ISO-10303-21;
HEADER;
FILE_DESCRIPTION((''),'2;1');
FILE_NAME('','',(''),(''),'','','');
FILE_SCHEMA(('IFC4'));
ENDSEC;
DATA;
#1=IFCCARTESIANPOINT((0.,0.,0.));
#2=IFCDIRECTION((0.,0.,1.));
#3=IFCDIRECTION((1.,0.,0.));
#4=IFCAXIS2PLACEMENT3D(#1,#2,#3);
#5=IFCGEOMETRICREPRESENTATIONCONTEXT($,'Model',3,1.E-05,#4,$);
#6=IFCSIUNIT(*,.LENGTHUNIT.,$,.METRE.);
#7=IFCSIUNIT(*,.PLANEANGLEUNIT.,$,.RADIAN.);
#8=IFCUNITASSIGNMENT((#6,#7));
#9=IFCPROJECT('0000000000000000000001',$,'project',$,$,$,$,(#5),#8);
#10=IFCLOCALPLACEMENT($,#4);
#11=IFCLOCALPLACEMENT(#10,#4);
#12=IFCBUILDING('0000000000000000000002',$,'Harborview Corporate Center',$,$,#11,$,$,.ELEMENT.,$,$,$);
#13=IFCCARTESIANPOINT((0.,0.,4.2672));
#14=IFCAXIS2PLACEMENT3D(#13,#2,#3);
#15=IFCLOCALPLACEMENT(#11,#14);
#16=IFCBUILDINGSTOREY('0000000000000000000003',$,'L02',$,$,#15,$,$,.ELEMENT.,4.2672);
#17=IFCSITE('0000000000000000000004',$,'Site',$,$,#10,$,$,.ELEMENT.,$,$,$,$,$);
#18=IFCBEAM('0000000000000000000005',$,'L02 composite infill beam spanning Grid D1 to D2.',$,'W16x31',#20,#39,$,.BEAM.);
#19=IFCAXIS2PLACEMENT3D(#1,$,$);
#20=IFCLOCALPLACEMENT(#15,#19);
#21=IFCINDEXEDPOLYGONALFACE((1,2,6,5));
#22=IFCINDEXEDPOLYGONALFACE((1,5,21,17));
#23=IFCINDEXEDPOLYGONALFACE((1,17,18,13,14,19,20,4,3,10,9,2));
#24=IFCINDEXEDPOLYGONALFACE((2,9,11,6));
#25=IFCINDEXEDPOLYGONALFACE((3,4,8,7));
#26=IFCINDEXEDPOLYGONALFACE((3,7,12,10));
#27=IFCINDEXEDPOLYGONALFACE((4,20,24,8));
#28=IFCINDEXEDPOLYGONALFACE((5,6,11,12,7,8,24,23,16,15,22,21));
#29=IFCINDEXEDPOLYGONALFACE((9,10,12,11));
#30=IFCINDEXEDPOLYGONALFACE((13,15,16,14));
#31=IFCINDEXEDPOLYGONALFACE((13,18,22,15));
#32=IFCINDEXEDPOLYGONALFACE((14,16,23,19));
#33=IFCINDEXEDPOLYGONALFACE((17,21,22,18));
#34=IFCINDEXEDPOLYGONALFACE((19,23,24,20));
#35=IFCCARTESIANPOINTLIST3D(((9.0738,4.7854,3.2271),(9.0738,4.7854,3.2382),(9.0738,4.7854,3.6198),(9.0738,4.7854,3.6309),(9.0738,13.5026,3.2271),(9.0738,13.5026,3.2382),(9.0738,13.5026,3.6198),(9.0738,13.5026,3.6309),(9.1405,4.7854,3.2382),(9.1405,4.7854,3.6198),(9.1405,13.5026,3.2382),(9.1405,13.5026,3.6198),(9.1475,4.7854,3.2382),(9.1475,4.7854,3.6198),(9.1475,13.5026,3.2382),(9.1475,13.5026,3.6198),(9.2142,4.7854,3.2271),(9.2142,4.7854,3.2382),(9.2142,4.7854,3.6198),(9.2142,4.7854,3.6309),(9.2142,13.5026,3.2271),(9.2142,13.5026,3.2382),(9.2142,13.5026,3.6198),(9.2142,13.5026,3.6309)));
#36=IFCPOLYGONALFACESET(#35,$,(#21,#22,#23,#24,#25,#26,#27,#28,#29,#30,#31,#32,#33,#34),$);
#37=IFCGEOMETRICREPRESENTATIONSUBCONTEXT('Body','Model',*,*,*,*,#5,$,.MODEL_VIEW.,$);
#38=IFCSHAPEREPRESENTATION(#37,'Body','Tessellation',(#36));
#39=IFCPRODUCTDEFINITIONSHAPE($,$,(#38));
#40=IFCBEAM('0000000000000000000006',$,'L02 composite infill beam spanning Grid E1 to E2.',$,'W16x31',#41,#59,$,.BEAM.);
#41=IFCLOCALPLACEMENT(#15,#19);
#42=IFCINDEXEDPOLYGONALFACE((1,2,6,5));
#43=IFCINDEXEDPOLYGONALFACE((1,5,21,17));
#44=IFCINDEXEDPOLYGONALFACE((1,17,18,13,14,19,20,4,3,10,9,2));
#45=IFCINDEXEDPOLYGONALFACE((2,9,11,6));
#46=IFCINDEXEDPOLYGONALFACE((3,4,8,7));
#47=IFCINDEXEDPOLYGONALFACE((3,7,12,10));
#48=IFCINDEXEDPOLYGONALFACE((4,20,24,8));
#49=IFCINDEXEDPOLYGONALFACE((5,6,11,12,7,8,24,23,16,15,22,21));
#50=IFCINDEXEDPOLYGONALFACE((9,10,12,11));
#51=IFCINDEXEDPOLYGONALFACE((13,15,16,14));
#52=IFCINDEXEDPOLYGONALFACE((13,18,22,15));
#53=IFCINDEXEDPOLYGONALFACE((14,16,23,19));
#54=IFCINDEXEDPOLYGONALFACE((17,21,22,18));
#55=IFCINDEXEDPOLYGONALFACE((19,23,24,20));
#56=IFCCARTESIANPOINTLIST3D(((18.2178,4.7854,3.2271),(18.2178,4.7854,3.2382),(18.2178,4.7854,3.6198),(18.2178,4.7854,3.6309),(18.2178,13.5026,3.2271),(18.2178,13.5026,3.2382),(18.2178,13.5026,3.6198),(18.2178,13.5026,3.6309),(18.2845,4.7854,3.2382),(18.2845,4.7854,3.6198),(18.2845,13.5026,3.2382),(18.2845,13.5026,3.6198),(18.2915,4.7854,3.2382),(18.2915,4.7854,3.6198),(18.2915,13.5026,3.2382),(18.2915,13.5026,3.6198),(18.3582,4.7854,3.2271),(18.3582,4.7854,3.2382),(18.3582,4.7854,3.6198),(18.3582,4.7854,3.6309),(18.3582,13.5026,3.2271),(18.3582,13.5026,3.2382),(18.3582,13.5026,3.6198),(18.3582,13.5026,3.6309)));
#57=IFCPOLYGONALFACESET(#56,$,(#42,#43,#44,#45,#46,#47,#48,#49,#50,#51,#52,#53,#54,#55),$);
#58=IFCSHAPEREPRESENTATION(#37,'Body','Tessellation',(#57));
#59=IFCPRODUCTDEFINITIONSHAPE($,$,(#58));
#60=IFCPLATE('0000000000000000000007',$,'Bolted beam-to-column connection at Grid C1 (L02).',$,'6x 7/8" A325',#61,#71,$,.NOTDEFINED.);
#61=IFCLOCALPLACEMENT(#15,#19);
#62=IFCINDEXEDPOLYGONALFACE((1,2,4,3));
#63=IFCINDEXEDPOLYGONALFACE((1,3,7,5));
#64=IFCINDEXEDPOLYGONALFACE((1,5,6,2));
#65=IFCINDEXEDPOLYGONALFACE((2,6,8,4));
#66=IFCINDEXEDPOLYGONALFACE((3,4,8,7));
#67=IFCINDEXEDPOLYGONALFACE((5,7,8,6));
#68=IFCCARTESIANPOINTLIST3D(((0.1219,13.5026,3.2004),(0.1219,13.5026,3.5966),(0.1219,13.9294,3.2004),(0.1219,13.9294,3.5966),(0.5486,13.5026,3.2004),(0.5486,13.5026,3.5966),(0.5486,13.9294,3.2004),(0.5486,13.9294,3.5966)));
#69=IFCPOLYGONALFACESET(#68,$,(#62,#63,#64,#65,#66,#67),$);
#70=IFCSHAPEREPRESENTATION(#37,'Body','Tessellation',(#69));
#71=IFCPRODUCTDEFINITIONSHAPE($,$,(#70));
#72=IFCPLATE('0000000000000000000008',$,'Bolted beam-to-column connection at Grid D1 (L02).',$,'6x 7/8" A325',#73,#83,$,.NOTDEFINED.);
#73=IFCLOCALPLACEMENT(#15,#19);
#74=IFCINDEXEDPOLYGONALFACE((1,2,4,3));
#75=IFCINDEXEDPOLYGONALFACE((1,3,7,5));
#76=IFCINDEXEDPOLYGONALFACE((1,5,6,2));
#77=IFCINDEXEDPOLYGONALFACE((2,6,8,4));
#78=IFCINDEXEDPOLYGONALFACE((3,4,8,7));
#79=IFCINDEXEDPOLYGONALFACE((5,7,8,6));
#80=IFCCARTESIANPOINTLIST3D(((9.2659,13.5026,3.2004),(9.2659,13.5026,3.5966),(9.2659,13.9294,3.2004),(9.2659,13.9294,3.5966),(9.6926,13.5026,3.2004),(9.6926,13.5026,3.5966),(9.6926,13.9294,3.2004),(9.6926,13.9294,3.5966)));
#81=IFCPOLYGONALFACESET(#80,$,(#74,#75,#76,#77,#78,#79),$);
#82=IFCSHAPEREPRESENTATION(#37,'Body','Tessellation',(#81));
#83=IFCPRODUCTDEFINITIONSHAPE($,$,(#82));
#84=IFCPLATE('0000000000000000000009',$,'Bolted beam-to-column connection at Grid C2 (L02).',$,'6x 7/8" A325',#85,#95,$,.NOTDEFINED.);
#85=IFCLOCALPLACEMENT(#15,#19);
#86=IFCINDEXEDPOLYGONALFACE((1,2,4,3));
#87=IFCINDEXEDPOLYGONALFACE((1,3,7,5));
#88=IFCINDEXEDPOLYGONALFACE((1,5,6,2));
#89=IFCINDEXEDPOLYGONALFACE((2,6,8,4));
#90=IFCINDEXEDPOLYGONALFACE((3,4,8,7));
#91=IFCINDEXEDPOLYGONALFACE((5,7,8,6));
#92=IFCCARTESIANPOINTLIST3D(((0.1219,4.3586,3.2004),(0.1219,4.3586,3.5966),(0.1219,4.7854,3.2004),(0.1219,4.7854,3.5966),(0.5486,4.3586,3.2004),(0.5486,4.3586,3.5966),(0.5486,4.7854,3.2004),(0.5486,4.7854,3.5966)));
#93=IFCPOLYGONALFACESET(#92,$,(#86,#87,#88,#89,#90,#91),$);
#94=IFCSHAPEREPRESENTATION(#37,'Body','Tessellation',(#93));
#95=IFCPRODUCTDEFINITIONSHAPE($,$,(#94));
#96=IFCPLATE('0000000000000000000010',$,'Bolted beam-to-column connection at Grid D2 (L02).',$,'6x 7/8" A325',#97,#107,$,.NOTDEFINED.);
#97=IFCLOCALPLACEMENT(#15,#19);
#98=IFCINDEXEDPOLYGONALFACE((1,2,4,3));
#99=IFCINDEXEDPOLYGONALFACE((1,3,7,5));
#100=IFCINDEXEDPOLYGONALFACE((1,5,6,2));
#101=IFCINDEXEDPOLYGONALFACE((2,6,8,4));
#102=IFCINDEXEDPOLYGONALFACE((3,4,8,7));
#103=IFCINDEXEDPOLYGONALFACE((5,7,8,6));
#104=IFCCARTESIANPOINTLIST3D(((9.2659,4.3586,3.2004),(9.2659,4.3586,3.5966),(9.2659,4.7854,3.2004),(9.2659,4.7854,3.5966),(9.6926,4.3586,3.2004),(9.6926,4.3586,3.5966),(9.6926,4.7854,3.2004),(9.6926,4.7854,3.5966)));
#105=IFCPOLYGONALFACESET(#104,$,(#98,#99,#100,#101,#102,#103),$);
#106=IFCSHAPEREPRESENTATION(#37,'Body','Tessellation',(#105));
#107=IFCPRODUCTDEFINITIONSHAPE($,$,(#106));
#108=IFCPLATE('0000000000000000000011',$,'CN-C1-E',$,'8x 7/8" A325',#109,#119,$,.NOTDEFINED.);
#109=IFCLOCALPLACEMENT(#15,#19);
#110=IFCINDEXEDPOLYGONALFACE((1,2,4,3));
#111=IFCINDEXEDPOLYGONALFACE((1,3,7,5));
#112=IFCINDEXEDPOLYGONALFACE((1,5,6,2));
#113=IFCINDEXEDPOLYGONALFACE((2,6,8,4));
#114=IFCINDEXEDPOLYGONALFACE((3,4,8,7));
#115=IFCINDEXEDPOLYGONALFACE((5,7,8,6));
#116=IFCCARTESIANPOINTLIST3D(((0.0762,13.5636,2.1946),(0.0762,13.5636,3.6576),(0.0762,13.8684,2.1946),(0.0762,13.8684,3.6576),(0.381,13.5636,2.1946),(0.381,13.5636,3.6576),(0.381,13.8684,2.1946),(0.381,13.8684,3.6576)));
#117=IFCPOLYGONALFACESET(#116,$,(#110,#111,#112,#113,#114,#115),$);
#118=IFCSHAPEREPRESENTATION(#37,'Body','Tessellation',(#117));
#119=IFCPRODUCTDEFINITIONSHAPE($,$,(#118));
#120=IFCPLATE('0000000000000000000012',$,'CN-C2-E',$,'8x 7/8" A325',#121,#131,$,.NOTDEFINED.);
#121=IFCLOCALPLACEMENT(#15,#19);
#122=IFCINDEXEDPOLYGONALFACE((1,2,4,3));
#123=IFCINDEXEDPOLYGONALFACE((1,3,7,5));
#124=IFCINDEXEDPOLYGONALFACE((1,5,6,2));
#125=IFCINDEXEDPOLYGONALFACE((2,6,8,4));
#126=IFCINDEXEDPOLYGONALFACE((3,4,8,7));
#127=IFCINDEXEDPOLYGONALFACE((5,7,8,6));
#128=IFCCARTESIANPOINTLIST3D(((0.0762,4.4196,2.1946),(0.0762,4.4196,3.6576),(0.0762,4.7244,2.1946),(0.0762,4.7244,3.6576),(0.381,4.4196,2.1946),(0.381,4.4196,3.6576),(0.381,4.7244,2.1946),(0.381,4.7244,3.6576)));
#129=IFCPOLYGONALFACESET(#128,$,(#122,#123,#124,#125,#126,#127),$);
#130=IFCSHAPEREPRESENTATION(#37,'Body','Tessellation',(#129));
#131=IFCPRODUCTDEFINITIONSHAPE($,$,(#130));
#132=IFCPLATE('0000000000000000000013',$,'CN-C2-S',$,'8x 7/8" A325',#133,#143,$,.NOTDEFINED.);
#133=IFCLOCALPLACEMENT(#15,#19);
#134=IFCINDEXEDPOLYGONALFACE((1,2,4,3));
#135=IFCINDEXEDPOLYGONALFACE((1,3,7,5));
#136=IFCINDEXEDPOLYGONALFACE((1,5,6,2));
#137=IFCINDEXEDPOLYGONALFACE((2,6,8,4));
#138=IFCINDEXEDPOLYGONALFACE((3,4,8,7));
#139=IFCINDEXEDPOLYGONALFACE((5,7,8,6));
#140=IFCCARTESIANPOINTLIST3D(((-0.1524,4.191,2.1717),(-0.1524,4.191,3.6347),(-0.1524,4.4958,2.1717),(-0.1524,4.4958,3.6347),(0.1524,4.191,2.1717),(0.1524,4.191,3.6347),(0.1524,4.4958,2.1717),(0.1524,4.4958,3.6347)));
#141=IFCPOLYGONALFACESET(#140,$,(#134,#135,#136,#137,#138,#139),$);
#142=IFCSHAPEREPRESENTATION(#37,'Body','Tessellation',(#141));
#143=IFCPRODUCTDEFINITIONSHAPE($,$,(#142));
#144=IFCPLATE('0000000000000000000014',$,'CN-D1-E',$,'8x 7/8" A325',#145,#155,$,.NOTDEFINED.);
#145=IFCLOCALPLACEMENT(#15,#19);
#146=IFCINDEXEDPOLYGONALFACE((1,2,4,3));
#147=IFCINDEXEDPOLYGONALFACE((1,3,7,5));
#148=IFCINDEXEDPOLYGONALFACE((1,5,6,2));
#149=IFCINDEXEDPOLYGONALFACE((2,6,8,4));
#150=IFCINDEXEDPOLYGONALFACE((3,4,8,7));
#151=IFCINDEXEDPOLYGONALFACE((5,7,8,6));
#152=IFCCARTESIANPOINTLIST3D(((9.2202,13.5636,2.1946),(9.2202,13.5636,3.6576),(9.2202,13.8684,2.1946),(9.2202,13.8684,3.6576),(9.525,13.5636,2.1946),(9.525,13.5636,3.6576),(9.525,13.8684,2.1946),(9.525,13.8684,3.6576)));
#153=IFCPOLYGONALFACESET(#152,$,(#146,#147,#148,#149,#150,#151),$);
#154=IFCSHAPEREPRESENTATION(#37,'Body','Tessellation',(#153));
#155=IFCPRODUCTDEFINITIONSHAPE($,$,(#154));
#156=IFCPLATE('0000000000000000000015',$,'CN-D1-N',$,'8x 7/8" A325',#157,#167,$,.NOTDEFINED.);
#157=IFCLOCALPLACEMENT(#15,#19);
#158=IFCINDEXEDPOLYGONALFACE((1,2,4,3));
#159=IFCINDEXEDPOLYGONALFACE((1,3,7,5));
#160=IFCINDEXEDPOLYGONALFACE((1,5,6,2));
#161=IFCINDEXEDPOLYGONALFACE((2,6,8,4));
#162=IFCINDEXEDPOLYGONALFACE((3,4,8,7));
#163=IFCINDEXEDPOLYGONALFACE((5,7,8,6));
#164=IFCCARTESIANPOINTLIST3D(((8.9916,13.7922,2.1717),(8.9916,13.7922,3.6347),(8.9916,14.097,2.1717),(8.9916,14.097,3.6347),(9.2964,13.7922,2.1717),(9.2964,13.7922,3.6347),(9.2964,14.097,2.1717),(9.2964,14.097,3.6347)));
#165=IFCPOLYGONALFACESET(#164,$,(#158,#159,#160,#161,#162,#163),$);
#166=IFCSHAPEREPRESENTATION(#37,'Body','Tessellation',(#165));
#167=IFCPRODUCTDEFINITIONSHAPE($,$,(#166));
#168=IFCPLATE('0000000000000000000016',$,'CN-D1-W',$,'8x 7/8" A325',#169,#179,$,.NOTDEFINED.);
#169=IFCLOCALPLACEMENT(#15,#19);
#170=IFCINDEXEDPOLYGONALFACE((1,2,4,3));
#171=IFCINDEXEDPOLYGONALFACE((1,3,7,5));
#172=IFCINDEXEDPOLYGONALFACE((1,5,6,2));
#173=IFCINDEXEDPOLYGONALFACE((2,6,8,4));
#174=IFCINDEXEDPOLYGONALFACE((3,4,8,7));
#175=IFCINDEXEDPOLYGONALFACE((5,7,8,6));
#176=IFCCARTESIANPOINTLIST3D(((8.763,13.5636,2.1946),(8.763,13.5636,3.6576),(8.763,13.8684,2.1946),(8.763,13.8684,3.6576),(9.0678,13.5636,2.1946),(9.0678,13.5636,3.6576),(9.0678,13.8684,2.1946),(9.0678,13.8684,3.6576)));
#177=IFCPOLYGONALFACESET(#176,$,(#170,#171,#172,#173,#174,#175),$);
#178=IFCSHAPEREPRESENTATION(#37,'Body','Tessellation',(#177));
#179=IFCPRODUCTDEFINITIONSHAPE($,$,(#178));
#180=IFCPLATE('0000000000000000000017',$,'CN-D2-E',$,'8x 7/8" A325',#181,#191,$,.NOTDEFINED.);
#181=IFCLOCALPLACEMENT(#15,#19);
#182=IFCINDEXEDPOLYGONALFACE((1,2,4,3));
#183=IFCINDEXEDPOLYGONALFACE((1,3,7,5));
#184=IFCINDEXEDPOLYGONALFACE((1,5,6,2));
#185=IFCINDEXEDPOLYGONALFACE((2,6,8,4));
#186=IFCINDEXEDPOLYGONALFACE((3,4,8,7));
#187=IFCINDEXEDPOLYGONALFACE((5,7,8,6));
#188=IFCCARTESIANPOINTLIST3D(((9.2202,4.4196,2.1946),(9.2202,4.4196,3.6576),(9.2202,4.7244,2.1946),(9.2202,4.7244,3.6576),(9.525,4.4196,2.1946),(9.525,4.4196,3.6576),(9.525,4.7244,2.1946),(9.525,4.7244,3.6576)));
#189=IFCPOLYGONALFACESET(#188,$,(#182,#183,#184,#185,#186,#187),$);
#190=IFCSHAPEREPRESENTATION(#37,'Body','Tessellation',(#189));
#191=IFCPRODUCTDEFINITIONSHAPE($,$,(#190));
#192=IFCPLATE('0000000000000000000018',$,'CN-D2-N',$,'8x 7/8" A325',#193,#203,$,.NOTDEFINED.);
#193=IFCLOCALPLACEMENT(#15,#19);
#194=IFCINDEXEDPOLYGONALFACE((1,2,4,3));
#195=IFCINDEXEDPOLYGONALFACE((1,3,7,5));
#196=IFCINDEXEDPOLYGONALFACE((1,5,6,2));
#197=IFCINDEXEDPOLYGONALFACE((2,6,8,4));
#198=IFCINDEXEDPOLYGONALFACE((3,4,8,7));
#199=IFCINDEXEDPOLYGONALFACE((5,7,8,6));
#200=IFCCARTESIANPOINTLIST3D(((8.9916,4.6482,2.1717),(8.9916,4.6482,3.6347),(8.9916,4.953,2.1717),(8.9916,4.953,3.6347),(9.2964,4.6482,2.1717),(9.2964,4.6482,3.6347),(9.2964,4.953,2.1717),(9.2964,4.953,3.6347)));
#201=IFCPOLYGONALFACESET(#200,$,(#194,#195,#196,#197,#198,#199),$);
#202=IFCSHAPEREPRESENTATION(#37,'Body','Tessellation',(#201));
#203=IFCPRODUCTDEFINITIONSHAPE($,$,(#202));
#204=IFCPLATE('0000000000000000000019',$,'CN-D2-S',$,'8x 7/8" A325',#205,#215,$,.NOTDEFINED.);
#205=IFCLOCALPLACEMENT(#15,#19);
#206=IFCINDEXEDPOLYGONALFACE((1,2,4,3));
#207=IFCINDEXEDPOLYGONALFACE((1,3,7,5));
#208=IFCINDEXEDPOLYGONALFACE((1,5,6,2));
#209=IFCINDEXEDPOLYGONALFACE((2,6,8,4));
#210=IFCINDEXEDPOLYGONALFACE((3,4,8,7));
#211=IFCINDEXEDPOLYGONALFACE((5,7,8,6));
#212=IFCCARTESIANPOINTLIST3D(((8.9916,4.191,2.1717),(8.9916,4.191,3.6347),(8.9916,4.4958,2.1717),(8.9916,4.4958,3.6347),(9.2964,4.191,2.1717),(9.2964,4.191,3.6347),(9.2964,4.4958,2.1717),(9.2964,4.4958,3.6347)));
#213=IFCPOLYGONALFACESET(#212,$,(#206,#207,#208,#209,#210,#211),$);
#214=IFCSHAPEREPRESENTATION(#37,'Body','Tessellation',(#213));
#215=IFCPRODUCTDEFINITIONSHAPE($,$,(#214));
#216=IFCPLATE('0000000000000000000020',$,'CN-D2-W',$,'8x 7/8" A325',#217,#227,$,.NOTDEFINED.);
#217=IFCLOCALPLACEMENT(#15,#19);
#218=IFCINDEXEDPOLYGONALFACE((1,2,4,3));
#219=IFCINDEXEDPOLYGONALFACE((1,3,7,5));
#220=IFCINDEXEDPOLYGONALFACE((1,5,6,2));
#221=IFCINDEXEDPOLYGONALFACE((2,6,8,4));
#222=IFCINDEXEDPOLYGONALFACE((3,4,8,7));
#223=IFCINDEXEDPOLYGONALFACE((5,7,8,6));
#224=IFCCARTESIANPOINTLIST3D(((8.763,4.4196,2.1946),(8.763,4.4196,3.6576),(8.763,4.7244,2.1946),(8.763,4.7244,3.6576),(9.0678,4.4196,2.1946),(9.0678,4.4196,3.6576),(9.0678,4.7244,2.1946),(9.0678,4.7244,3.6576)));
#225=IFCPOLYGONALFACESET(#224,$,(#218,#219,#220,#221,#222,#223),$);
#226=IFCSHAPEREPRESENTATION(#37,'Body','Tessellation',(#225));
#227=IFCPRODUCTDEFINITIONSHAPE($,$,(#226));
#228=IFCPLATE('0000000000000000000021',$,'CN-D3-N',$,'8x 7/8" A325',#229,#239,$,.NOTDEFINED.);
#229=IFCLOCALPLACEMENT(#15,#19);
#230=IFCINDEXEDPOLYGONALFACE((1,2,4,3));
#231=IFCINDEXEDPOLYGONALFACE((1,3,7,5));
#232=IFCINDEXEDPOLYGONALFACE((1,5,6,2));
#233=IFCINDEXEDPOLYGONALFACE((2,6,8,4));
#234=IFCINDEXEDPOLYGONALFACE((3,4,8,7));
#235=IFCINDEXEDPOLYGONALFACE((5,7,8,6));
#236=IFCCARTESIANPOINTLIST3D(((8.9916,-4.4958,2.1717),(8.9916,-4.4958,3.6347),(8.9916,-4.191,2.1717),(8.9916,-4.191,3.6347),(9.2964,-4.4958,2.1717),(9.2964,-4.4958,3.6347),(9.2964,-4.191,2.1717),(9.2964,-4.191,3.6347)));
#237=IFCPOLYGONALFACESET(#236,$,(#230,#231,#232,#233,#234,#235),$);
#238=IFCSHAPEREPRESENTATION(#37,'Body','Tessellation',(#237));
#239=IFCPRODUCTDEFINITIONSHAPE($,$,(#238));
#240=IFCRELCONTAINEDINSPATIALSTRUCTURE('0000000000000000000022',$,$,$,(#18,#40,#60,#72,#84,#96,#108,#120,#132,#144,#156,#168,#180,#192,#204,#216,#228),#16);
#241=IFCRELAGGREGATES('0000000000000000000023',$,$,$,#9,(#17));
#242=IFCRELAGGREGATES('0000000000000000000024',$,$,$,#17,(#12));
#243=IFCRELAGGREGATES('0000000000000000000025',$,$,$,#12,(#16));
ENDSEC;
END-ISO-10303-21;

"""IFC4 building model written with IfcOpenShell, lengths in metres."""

from ifc_helpers import new_model, si_unit, frame, origin_with_axes, place, context, subcontext, project, spatial, rectangle, i_section, extrude, element, save


model = new_model("IFC4")

# Units and contexts
model_context = context("Model", 3, precision=1e-05, world=origin_with_axes())
body_context = subcontext(model_context, "Body", "Model", "MODEL_VIEW")
ifc_project = project(units=[si_unit("LENGTHUNIT", "METRE"), si_unit("PLANEANGLEUNIT", "RADIAN")], contexts=[model_context])

# Site, building, storey
site_placement = place(None, origin_with_axes())
site = spatial("IfcSite", under=ifc_project, at=site_placement, Name="Site", CompositionType="ELEMENT")
building_placement = place(site_placement, origin_with_axes())
building = spatial("IfcBuilding", under=site, at=building_placement, Name="Harborview Corporate Center", CompositionType="ELEMENT")
storey_placement = place(building_placement, frame((0.0, 0.0, 4.2672), z_axis=(0.0, 0.0, 1.0), x_axis=(1.0, 0.0, 0.0)))
storey = spatial("IfcBuildingStorey", under=building, at=storey_placement, Name="L02", CompositionType="ELEMENT", Elevation=4.2672)

# Beams
for number, where, z_axis, x_axis, name in (
    (1, (9.144, 4.7854, 3.429), (0.0, 1.0, 0.0), (-1.0, 0.0, 0.0), "L02 composite infill beam spanning Grid D1 to D2."),
    (2, (18.288, 4.7854, 3.429), (0.0, 1.0, 0.0), (-1.0, 0.0, 0.0), "L02 composite infill beam spanning Grid E1 to E2."),
):
    element("IfcBeam", number, at=place(storey_placement, frame(where, z_axis=z_axis, x_axis=x_axis)), inside=storey, Name=name, ObjectType="W16x31", PredefinedType="BEAM", context=body_context, shape_type="SweptSolid", body=[
        extrude(i_section(OverallWidth=0.1405, OverallDepth=0.4039, WebThickness=0.007, FlangeThickness=0.0112), origin_with_axes(), (0.0, 0.0, 1.0), 8.7173),
    ])

# Plates
plate_1_placement = place(storey_placement, frame((0.3353, 13.716, 3.2004), z_axis=(0.0, 0.0, 1.0), x_axis=(1.0, 0.0, 0.0)))
element("IfcPlate", 3, at=plate_1_placement, inside=storey, Name="Bolted beam-to-column connection at Grid C1 (L02).", ObjectType="6x 7/8\" A325", PredefinedType="NOTDEFINED", context=body_context, shape_type="SweptSolid", body=[
    extrude(rectangle(XDim=0.4267, YDim=0.4267), origin_with_axes(), (0.0, 0.0, 1.0), 0.3962),
])
plate_2_placement = place(storey_placement, frame((9.4793, 13.716, 3.2004), z_axis=(0.0, 0.0, 1.0), x_axis=(1.0, 0.0, 0.0)))
element("IfcPlate", 4, at=plate_2_placement, inside=storey, Name="Bolted beam-to-column connection at Grid D1 (L02).", ObjectType="6x 7/8\" A325", PredefinedType="NOTDEFINED", context=body_context, shape_type="SweptSolid", body=[
    extrude(rectangle(XDim=0.4267, YDim=0.4267), origin_with_axes(), (0.0, 0.0, 1.0), 0.3962),
])
plate_3_placement = place(storey_placement, frame((0.3353, 4.572, 3.2004), z_axis=(0.0, 0.0, 1.0), x_axis=(1.0, 0.0, 0.0)))
element("IfcPlate", 5, at=plate_3_placement, inside=storey, Name="Bolted beam-to-column connection at Grid C2 (L02).", ObjectType="6x 7/8\" A325", PredefinedType="NOTDEFINED", context=body_context, shape_type="SweptSolid", body=[
    extrude(rectangle(XDim=0.4267, YDim=0.4267), origin_with_axes(), (0.0, 0.0, 1.0), 0.3962),
])
plate_4_placement = place(storey_placement, frame((9.4793, 4.572, 3.2004), z_axis=(0.0, 0.0, 1.0), x_axis=(1.0, 0.0, 0.0)))
element("IfcPlate", 6, at=plate_4_placement, inside=storey, Name="Bolted beam-to-column connection at Grid D2 (L02).", ObjectType="6x 7/8\" A325", PredefinedType="NOTDEFINED", context=body_context, shape_type="SweptSolid", body=[
    extrude(rectangle(XDim=0.4267, YDim=0.4267), origin_with_axes(), (0.0, 0.0, 1.0), 0.3962),
])
for number, where, z_axis, x_axis, name in (
    (7, (0.2286, 13.716, 2.1946), (0.0, 0.0, 1.0), (1.0, 0.0, 0.0), "CN-C1-E"),
    (8, (0.2286, 4.572, 2.1946), (0.0, 0.0, 1.0), (1.0, 0.0, 0.0), "CN-C2-E"),
    (9, (0.0, 4.3434, 2.1717), (0.0, 0.0, 1.0), (1.0, 0.0, 0.0), "CN-C2-S"),
):
    element("IfcPlate", number, at=place(storey_placement, frame(where, z_axis=z_axis, x_axis=x_axis)), inside=storey, Name=name, ObjectType="8x 7/8\" A325", PredefinedType="NOTDEFINED", context=body_context, shape_type="SweptSolid", body=[
        extrude(rectangle(XDim=0.3048, YDim=0.3048), origin_with_axes(), (0.0, 0.0, 1.0), 1.463),
    ])
for number, where, z_axis, x_axis, name in (
    (10, (9.3726, 13.716, 2.1946), (0.0, 0.0, 1.0), (1.0, 0.0, 0.0), "CN-D1-E"),
    (11, (9.144, 13.9446, 2.1717), (0.0, 0.0, 1.0), (1.0, 0.0, 0.0), "CN-D1-N"),
    (12, (8.9154, 13.716, 2.1946), (0.0, 0.0, 1.0), (1.0, 0.0, 0.0), "CN-D1-W"),
    (13, (9.3726, 4.572, 2.1946), (0.0, 0.0, 1.0), (1.0, 0.0, 0.0), "CN-D2-E"),
    (14, (9.144, 4.8006, 2.1717), (0.0, 0.0, 1.0), (1.0, 0.0, 0.0), "CN-D2-N"),
    (15, (9.144, 4.3434, 2.1717), (0.0, 0.0, 1.0), (1.0, 0.0, 0.0), "CN-D2-S"),
    (16, (8.9154, 4.572, 2.1946), (0.0, 0.0, 1.0), (1.0, 0.0, 0.0), "CN-D2-W"),
    (17, (9.144, -4.3434, 2.1717), (0.0, 0.0, 1.0), (1.0, 0.0, 0.0), "CN-D3-N"),
):
    element("IfcPlate", number, at=place(storey_placement, frame(where, z_axis=z_axis, x_axis=x_axis)), inside=storey, Name=name, ObjectType="8x 7/8\" A325", PredefinedType="NOTDEFINED", context=body_context, shape_type="SweptSolid", body=[
        extrude(rectangle(XDim=0.3048, YDim=0.3048), origin_with_axes(), (0.0, 0.0, 1.0), 1.463),
    ])

save(model, "model.ifc")
